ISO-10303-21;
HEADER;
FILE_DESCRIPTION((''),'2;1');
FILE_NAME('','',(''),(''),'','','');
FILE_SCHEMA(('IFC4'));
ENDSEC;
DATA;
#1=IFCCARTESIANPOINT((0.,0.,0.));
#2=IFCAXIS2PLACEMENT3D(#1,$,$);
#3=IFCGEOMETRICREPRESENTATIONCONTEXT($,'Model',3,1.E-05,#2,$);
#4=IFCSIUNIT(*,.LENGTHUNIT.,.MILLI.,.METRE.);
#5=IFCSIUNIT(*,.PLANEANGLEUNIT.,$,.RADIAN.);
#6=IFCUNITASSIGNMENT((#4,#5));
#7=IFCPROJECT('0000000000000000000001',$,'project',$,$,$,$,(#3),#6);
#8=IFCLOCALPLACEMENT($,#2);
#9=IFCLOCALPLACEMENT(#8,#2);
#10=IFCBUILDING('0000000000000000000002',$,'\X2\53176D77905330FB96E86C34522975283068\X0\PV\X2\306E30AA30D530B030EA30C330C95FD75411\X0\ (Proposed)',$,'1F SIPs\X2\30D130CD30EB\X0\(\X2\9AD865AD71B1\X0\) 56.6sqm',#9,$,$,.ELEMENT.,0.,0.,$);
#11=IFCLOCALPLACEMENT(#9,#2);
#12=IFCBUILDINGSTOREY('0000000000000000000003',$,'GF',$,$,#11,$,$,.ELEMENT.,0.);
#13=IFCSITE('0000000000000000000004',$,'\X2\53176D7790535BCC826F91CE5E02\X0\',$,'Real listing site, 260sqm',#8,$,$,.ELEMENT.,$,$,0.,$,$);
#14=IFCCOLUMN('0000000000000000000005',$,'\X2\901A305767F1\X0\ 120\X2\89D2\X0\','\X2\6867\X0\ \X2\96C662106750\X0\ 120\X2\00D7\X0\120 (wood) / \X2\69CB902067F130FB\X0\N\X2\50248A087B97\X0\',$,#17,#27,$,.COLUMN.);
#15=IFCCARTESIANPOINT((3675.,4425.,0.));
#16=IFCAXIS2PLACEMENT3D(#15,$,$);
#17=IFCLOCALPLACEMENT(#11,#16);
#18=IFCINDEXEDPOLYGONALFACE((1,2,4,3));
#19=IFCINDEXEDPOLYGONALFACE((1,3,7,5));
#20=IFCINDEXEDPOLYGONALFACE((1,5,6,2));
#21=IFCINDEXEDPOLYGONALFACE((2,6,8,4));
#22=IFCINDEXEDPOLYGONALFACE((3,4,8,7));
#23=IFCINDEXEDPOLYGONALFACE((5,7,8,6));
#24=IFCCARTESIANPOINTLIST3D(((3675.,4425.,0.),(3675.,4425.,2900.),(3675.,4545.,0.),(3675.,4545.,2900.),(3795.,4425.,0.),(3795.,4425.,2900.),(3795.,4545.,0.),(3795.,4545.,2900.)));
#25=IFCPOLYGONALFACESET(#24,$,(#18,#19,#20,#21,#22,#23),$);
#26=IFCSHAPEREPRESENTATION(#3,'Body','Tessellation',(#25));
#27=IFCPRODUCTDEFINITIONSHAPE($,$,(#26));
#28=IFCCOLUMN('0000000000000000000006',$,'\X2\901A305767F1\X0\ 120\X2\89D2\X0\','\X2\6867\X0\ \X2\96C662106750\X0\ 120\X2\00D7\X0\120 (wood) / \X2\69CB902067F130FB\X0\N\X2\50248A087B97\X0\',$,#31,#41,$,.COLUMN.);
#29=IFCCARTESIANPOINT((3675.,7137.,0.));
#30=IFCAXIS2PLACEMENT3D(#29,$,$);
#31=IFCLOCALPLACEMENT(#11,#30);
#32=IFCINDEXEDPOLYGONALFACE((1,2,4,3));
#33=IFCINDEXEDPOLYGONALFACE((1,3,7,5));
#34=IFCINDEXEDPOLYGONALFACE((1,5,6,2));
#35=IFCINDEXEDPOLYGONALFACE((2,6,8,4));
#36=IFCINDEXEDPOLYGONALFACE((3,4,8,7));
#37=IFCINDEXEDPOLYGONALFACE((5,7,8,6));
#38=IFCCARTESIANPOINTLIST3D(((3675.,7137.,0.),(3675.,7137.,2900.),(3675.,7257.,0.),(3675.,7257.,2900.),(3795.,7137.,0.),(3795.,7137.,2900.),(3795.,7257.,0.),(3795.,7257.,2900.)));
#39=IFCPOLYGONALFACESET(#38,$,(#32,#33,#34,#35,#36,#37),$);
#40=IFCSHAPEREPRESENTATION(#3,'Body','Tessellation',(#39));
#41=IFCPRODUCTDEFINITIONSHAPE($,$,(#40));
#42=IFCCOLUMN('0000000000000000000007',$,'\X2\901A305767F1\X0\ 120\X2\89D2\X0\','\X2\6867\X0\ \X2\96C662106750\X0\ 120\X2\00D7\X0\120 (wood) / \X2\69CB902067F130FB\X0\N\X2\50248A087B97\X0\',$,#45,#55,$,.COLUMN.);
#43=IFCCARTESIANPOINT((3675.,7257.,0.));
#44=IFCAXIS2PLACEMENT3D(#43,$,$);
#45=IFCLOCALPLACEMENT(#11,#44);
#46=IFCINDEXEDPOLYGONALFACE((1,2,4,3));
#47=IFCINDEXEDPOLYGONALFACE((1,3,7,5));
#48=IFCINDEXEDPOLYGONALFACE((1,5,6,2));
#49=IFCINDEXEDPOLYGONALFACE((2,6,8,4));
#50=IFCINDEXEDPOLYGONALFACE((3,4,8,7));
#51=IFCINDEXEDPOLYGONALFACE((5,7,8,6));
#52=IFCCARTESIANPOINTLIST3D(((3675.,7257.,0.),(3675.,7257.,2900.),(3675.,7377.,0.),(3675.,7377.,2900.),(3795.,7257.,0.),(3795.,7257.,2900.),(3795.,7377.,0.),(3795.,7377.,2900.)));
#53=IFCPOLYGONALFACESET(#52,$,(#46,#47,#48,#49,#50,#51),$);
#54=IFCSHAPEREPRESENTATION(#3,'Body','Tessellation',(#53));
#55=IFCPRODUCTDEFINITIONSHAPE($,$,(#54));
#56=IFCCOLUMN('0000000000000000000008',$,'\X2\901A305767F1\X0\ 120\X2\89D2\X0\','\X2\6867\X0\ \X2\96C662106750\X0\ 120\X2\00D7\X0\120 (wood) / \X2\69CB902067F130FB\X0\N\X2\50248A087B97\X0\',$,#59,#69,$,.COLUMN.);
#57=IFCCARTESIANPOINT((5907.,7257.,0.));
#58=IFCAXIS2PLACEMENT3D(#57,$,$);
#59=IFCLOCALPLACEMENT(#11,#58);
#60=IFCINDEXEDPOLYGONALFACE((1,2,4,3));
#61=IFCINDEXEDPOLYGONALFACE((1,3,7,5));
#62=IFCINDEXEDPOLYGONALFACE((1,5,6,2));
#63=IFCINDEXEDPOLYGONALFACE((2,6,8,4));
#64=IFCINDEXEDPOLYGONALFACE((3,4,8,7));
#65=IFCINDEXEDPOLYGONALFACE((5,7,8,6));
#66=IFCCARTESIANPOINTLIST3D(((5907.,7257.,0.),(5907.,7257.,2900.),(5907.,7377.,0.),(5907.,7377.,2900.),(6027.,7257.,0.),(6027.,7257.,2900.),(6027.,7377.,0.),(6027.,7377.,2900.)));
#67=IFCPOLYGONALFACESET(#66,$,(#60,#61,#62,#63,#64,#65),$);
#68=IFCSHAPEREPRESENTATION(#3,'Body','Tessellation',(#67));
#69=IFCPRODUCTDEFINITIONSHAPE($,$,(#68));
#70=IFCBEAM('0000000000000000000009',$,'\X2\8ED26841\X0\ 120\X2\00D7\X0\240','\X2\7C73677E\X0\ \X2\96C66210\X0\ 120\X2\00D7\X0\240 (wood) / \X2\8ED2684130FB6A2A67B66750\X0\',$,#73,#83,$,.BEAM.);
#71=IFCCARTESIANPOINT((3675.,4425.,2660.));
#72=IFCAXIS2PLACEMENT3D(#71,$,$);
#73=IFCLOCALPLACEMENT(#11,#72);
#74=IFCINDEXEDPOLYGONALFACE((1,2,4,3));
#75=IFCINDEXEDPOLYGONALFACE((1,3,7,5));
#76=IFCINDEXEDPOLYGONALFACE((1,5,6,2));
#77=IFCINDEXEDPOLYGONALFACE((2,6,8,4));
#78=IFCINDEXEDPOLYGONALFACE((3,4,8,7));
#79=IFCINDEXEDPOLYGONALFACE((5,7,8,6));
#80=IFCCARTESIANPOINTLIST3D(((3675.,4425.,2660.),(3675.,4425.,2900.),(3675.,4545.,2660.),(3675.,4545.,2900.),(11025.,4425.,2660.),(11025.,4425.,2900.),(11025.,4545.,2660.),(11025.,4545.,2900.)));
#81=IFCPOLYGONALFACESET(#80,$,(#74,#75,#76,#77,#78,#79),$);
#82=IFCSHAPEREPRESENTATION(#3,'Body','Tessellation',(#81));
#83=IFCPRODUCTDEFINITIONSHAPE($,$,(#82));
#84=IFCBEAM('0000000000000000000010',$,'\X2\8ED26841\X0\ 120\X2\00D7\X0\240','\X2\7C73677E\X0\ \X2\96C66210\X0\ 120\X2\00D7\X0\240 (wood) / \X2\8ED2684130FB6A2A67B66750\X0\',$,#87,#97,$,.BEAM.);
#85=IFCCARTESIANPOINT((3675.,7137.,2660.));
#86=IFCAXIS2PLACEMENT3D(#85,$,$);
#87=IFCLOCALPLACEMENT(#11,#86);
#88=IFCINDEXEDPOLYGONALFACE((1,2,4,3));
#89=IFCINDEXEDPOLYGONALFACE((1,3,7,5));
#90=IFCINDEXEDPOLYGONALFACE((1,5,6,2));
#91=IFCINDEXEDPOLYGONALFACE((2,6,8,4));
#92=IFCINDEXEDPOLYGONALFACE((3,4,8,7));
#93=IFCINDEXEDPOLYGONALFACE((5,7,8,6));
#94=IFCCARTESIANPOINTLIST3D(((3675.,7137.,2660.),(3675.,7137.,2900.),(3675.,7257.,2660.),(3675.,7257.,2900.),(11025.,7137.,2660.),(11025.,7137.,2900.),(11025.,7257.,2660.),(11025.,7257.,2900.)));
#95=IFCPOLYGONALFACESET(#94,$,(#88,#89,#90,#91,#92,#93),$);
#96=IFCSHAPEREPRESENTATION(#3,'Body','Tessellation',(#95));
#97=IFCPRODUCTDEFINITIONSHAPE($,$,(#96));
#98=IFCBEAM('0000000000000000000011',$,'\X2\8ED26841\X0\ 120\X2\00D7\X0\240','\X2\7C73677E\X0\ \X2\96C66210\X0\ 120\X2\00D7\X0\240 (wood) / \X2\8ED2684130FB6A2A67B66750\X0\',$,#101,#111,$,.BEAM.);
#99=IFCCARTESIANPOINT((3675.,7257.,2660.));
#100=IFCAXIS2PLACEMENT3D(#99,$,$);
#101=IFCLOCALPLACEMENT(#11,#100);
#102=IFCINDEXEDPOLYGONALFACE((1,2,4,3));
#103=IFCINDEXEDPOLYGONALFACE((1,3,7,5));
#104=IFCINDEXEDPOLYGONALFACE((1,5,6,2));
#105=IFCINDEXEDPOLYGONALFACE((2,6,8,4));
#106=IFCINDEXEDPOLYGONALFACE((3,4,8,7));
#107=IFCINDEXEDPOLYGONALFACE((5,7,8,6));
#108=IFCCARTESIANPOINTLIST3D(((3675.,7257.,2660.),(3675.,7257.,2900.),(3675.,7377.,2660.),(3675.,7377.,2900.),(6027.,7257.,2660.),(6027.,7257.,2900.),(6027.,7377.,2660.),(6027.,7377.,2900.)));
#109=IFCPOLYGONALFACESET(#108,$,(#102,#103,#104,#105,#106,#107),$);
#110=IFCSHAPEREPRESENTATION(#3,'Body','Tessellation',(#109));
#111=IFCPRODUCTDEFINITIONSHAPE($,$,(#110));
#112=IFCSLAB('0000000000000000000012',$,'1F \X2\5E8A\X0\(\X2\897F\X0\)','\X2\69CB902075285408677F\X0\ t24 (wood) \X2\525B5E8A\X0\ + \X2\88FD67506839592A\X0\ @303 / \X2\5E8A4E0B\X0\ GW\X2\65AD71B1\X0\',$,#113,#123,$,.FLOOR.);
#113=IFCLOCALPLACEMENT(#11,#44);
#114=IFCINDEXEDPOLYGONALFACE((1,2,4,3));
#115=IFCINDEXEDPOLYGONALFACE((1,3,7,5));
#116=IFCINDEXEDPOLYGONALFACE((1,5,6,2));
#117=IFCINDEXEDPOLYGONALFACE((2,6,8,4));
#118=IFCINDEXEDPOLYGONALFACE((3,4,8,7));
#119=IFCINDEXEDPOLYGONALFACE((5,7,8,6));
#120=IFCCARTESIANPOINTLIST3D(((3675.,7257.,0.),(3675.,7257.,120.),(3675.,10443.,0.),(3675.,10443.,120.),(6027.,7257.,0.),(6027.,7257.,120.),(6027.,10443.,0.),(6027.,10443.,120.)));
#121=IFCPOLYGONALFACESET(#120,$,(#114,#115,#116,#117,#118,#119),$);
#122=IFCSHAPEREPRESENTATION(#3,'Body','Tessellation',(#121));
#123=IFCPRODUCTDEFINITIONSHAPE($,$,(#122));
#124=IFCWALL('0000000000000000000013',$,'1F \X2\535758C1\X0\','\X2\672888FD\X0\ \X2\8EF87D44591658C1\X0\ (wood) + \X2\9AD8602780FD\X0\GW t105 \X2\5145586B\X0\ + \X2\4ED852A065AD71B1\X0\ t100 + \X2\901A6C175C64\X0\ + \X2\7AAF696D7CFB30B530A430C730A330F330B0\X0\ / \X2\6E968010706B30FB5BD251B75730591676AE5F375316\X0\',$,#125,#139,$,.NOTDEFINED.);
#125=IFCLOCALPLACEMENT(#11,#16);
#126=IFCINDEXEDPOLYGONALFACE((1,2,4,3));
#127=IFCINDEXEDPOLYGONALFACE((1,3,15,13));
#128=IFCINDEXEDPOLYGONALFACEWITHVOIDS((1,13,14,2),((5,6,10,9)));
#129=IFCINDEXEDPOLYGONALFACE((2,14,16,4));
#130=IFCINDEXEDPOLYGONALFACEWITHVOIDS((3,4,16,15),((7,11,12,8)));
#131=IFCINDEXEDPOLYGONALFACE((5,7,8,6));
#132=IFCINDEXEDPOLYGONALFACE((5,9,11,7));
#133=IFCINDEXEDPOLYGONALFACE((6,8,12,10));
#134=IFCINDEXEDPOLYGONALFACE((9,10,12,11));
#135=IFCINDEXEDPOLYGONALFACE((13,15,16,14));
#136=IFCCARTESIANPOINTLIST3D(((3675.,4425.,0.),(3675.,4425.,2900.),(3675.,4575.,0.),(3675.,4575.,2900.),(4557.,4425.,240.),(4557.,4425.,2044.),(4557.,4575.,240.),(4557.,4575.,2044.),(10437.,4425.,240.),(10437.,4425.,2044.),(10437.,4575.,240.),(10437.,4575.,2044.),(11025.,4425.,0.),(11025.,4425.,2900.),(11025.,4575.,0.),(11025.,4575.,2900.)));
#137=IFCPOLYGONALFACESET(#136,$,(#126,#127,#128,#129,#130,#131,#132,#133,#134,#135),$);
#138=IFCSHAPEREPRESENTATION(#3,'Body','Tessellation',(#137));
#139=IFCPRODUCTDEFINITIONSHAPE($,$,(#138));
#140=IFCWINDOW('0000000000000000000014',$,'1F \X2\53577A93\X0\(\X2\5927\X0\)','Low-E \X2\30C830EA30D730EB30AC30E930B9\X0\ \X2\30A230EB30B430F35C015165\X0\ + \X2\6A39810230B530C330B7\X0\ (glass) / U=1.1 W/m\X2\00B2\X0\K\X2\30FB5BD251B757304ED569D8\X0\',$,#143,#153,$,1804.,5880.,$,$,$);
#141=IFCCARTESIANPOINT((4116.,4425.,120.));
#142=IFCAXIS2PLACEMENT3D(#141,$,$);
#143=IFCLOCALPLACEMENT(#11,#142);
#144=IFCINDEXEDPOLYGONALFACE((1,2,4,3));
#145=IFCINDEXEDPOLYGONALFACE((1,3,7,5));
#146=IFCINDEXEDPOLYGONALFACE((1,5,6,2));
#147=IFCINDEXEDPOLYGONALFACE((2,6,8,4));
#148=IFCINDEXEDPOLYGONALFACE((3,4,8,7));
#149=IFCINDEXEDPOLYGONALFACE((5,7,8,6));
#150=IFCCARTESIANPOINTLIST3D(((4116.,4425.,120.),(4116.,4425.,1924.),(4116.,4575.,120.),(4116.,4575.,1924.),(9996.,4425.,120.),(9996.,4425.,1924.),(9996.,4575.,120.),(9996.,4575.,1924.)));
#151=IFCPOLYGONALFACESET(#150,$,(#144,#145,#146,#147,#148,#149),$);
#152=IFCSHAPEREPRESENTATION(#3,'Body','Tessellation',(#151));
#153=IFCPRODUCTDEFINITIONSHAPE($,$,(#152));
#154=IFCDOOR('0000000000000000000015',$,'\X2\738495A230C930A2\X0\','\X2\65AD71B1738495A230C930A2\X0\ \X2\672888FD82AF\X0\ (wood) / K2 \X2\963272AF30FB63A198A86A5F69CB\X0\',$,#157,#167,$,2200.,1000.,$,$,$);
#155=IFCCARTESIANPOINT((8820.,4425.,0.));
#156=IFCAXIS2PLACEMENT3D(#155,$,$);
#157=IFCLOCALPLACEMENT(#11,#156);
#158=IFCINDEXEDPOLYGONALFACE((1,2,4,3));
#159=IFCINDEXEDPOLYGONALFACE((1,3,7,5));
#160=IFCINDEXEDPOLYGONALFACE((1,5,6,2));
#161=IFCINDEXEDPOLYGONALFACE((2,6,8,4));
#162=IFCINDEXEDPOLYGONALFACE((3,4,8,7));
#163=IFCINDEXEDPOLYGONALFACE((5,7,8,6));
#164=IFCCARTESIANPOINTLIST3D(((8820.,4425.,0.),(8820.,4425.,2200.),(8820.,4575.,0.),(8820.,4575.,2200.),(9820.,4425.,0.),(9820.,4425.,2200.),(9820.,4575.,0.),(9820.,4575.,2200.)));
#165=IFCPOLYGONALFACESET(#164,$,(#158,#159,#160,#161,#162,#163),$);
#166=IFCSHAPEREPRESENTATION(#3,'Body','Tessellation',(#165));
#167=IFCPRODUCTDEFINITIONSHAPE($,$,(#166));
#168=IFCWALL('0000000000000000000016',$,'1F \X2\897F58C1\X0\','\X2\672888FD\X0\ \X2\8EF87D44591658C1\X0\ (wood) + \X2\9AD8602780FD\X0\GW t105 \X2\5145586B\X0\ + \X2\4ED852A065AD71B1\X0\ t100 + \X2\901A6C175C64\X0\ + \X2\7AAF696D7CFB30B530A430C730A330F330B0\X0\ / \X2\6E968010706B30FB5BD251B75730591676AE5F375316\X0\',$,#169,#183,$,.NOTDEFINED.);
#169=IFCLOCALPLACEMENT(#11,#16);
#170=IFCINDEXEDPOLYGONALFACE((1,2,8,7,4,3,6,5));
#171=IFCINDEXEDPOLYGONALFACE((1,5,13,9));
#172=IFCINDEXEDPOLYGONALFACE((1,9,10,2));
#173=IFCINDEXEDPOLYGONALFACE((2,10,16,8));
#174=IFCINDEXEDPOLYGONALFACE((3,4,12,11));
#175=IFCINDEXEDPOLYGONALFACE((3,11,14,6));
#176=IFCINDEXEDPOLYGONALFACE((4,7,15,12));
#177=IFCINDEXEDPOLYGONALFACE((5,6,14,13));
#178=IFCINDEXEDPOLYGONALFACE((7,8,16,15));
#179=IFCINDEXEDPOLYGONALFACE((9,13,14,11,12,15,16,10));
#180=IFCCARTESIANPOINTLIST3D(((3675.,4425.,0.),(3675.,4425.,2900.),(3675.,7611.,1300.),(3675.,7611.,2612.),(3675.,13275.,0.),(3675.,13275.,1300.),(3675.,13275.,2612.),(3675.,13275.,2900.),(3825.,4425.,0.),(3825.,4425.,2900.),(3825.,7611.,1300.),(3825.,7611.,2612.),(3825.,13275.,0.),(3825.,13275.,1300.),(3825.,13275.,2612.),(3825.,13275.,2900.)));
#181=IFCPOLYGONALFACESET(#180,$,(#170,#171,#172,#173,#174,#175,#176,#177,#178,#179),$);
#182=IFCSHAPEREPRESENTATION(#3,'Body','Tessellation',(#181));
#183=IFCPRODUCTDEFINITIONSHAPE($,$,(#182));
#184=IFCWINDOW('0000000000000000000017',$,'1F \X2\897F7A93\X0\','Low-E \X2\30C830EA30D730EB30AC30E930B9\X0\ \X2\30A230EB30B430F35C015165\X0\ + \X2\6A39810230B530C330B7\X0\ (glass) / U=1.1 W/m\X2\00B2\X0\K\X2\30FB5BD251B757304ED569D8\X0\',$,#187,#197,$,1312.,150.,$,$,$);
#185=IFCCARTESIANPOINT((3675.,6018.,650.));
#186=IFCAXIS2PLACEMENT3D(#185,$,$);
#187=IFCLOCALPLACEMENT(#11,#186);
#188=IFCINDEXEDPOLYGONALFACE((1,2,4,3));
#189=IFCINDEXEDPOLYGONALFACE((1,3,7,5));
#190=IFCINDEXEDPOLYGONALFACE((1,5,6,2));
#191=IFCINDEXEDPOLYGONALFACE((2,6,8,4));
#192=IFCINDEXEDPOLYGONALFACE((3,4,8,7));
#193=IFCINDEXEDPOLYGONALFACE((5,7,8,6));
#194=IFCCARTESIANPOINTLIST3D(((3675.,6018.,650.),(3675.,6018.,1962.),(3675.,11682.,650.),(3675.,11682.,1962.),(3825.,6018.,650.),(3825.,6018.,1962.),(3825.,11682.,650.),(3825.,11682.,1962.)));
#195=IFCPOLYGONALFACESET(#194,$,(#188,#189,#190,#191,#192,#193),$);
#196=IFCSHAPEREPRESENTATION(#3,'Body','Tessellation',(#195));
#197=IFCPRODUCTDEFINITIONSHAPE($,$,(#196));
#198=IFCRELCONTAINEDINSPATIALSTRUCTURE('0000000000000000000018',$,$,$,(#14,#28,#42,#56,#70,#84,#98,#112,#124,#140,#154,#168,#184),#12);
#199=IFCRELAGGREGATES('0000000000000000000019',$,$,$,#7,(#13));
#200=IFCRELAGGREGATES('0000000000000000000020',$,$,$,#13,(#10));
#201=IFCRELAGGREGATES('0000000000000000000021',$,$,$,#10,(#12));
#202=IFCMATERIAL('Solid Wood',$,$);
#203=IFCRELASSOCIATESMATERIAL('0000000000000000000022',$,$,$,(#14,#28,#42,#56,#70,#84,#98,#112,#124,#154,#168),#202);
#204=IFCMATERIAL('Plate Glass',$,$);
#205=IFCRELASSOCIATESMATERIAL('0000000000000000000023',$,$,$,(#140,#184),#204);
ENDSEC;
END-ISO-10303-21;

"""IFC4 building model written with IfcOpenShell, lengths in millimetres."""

from ifc_helpers import new_model, si_unit, frame, frame_2d, origin, place, context, project, spatial, rectangle, extrude, material, element, fill, save


model = new_model("IFC4")

# Units and contexts
model_context = context("Model", 3, precision=1e-05, world=origin())
ifc_project = project(units=[si_unit("LENGTHUNIT", "METRE", prefix="MILLI"), si_unit("PLANEANGLEUNIT", "RADIAN")], contexts=[model_context])

# Site, building, storey
site_placement = place(None, origin())
site = spatial("IfcSite", under=ifc_project, at=site_placement, Name="北海道富良野市", ObjectType="Real listing site, 260sqm", CompositionType="ELEMENT", RefElevation=0.0)
building_placement = place(site_placement, origin())
building = spatial("IfcBuilding", under=site, at=building_placement, Name="北海道・雨水利用とPVのオフグリッド志向 (Proposed)", ObjectType="1F SIPsパネル(高断熱) 56.6sqm", CompositionType="ELEMENT", ElevationOfRefHeight=0.0, ElevationOfTerrain=0.0)
storey_placement = place(building_placement, origin())
storey = spatial("IfcBuildingStorey", under=building, at=storey_placement, Name="GF", CompositionType="ELEMENT", Elevation=0.0)

# Columns
ifc_material_1 = material(Name="Solid Wood")
column_1_placement = place(storey_placement, frame((3675.0, 4425.0, 0.0)))
element("IfcColumn", 1, at=column_1_placement, inside=storey, material=ifc_material_1, Name="通し柱 120角", Description="桧 集成材 120×120 (wood) / 構造柱・N値計算", PredefinedType="COLUMN", context=model_context, shape_type="SweptSolid", body=[
    extrude(rectangle(XDim=120.0, YDim=120.0, at=frame_2d((60.0, 60.0))), frame((3675.0, 4425.0, 0.0)), (0.0, 0.0, 1.0), 2900.0),
])
column_2_placement = place(storey_placement, frame((3675.0, 7137.0, 0.0)))
element("IfcColumn", 2, at=column_2_placement, inside=storey, material=ifc_material_1, Name="通し柱 120角", Description="桧 集成材 120×120 (wood) / 構造柱・N値計算", PredefinedType="COLUMN", context=model_context, shape_type="SweptSolid", body=[
    extrude(rectangle(XDim=120.0, YDim=120.0, at=frame_2d((60.0, 60.0))), frame((3675.0, 7137.0, 0.0)), (0.0, 0.0, 1.0), 2900.0),
])
column_3_placement = place(storey_placement, frame((3675.0, 7257.0, 0.0)))
element("IfcColumn", 3, at=column_3_placement, inside=storey, material=ifc_material_1, Name="通し柱 120角", Description="桧 集成材 120×120 (wood) / 構造柱・N値計算", PredefinedType="COLUMN", context=model_context, shape_type="SweptSolid", body=[
    extrude(rectangle(XDim=120.0, YDim=120.0, at=frame_2d((60.0, 60.0))), frame((3675.0, 7257.0, 0.0)), (0.0, 0.0, 1.0), 2900.0),
])
column_4_placement = place(storey_placement, frame((5907.0, 7257.0, 0.0)))
element("IfcColumn", 4, at=column_4_placement, inside=storey, material=ifc_material_1, Name="通し柱 120角", Description="桧 集成材 120×120 (wood) / 構造柱・N値計算", PredefinedType="COLUMN", context=model_context, shape_type="SweptSolid", body=[
    extrude(rectangle(XDim=120.0, YDim=120.0, at=frame_2d((60.0, 60.0))), frame((5907.0, 7257.0, 0.0)), (0.0, 0.0, 1.0), 2900.0),
])

# Beams
beam_1_placement = place(storey_placement, frame((3675.0, 4425.0, 2660.0)))
element("IfcBeam", 5, at=beam_1_placement, inside=storey, material=ifc_material_1, Name="軒桁 120×240", Description="米松 集成 120×240 (wood) / 軒桁・横架材", PredefinedType="BEAM", context=model_context, shape_type="SweptSolid", body=[
    extrude(rectangle(XDim=7350.0, YDim=120.0, at=frame_2d((3675.0, 60.0))), frame((3675.0, 4425.0, 2660.0)), (0.0, 0.0, 1.0), 240.0),
])
beam_2_placement = place(storey_placement, frame((3675.0, 7137.0, 2660.0)))
element("IfcBeam", 6, at=beam_2_placement, inside=storey, material=ifc_material_1, Name="軒桁 120×240", Description="米松 集成 120×240 (wood) / 軒桁・横架材", PredefinedType="BEAM", context=model_context, shape_type="SweptSolid", body=[
    extrude(rectangle(XDim=7350.0, YDim=120.0, at=frame_2d((3675.0, 60.0))), frame((3675.0, 7137.0, 2660.0)), (0.0, 0.0, 1.0), 240.0),
])
beam_3_placement = place(storey_placement, frame((3675.0, 7257.0, 2660.0)))
element("IfcBeam", 7, at=beam_3_placement, inside=storey, material=ifc_material_1, Name="軒桁 120×240", Description="米松 集成 120×240 (wood) / 軒桁・横架材", PredefinedType="BEAM", context=model_context, shape_type="SweptSolid", body=[
    extrude(rectangle(XDim=2352.0, YDim=120.0, at=frame_2d((1176.0, 60.0))), frame((3675.0, 7257.0, 2660.0)), (0.0, 0.0, 1.0), 240.0),
])

# Slab
slab_1_placement = place(storey_placement, frame((3675.0, 7257.0, 0.0)))
element("IfcSlab", 8, at=slab_1_placement, inside=storey, material=ifc_material_1, Name="1F 床(西)", Description="構造用合板 t24 (wood) 剛床 + 製材根太 @303 / 床下 GW断熱", PredefinedType="FLOOR", context=model_context, shape_type="SweptSolid", body=[
    extrude(rectangle(XDim=2352.0, YDim=3186.0, at=frame_2d((1176.0, 1593.0))), frame((3675.0, 7257.0, 0.0)), (0.0, 0.0, 1.0), 120.0),
])

# Wall, openings, window, door
wall_1_placement = place(storey_placement, frame((3675.0, 4425.0, 0.0)))
wall_1 = element("IfcWall", 9, at=wall_1_placement, inside=storey, material=ifc_material_1, Name="1F 南壁", Description="木製 軸組外壁 (wood) + 高性能GW t105 充填 + 付加断熱 t100 + 通気層 + 窯業系サイディング / 準耐火・寒冷地外皮強化", PredefinedType="NOTDEFINED", context=model_context, shape_type="SweptSolid", body=[
    extrude(rectangle(XDim=7350.0, YDim=150.0, at=frame_2d((3675.0, 75.0))), frame((3675.0, 4425.0, 0.0)), (0.0, 0.0, 1.0), 2900.0),
])
opening_1_placement = place(storey_placement, frame((4116.0, 4425.0, 120.0)))
opening_1 = element("IfcOpeningElement", 10, at=opening_1_placement, cuts=wall_1, PredefinedType="NOTDEFINED", context=model_context, shape_type="SweptSolid", body=[
    extrude(rectangle(XDim=5880.0, YDim=150.0, at=frame_2d((2940.0, 75.0))), frame((4116.0, 4425.0, 120.0)), (0.0, 0.0, 1.0), 1804.0),
])
opening_2_placement = place(storey_placement, frame((8820.0, 4425.0, 0.0)))
opening_2 = element("IfcOpeningElement", 11, at=opening_2_placement, cuts=wall_1, PredefinedType="NOTDEFINED", context=model_context, shape_type="SweptSolid", body=[
    extrude(rectangle(XDim=1000.0, YDim=150.0, at=frame_2d((500.0, 75.0))), frame((8820.0, 4425.0, 0.0)), (0.0, 0.0, 1.0), 2200.0),
])
ifc_material_2 = material(Name="Plate Glass")
window_1_placement = place(storey_placement, frame((4116.0, 4425.0, 120.0)))
window_1 = element("IfcWindow", 12, at=window_1_placement, inside=storey, material=ifc_material_2, Name="1F 南窓(大)", Description="Low-E トリプルガラス アルゴン封入 + 樹脂サッシ (glass) / U=1.1 W/m²K・寒冷地仕様", OverallHeight=1804.0, OverallWidth=5880.0, context=model_context, shape_type="SweptSolid", body=[
    extrude(rectangle(XDim=5880.0, YDim=150.0, at=frame_2d((2940.0, 75.0))), frame((4116.0, 4425.0, 120.0)), (0.0, 0.0, 1.0), 1804.0),
])
fill(opening_1, window_1)
door_placement = place(storey_placement, frame((8820.0, 4425.0, 0.0)))
door = element("IfcDoor", 13, at=door_placement, inside=storey, material=ifc_material_1, Name="玄関ドア", Description="断熱玄関ドア 木製芯 (wood) / K2 防犯・採風機構", OverallHeight=2200.0, OverallWidth=1000.0, context=model_context, shape_type="SweptSolid", body=[
    extrude(rectangle(XDim=1000.0, YDim=150.0, at=frame_2d((500.0, 75.0))), frame((8820.0, 4425.0, 0.0)), (0.0, 0.0, 1.0), 2200.0),
])
fill(opening_2, door)

# Wall, opening, window
wall_2_placement = place(storey_placement, frame((3675.0, 4425.0, 0.0)))
wall_2 = element("IfcWall", 14, at=wall_2_placement, inside=storey, material=ifc_material_1, Name="1F 西壁", Description="木製 軸組外壁 (wood) + 高性能GW t105 充填 + 付加断熱 t100 + 通気層 + 窯業系サイディング / 準耐火・寒冷地外皮強化", PredefinedType="NOTDEFINED", context=model_context, shape_type="SweptSolid", body=[
    extrude(rectangle(XDim=150.0, YDim=8850.0, at=frame_2d((75.0, 4425.0))), frame((3675.0, 4425.0, 0.0)), (0.0, 0.0, 1.0), 2900.0),
])
opening_3_placement = place(storey_placement, frame((3675.0, 6018.0, 650.0)))
opening_3 = element("IfcOpeningElement", 15, at=opening_3_placement, cuts=wall_2, PredefinedType="NOTDEFINED", context=model_context, shape_type="SweptSolid", body=[
    extrude(rectangle(XDim=150.0, YDim=5664.0, at=frame_2d((75.0, 2832.0))), frame((3675.0, 6018.0, 650.0)), (0.0, 0.0, 1.0), 1312.0),
])
window_2_placement = place(storey_placement, frame((3675.0, 6018.0, 650.0)))
window_2 = element("IfcWindow", 16, at=window_2_placement, inside=storey, material=ifc_material_2, Name="1F 西窓", Description="Low-E トリプルガラス アルゴン封入 + 樹脂サッシ (glass) / U=1.1 W/m²K・寒冷地仕様", OverallHeight=1312.0, OverallWidth=150.0, context=model_context, shape_type="SweptSolid", body=[
    extrude(rectangle(XDim=150.0, YDim=5664.0, at=frame_2d((75.0, 2832.0))), frame((3675.0, 6018.0, 650.0)), (0.0, 0.0, 1.0), 1312.0),
])
fill(opening_3, window_2)

save(model, "model.ifc")
